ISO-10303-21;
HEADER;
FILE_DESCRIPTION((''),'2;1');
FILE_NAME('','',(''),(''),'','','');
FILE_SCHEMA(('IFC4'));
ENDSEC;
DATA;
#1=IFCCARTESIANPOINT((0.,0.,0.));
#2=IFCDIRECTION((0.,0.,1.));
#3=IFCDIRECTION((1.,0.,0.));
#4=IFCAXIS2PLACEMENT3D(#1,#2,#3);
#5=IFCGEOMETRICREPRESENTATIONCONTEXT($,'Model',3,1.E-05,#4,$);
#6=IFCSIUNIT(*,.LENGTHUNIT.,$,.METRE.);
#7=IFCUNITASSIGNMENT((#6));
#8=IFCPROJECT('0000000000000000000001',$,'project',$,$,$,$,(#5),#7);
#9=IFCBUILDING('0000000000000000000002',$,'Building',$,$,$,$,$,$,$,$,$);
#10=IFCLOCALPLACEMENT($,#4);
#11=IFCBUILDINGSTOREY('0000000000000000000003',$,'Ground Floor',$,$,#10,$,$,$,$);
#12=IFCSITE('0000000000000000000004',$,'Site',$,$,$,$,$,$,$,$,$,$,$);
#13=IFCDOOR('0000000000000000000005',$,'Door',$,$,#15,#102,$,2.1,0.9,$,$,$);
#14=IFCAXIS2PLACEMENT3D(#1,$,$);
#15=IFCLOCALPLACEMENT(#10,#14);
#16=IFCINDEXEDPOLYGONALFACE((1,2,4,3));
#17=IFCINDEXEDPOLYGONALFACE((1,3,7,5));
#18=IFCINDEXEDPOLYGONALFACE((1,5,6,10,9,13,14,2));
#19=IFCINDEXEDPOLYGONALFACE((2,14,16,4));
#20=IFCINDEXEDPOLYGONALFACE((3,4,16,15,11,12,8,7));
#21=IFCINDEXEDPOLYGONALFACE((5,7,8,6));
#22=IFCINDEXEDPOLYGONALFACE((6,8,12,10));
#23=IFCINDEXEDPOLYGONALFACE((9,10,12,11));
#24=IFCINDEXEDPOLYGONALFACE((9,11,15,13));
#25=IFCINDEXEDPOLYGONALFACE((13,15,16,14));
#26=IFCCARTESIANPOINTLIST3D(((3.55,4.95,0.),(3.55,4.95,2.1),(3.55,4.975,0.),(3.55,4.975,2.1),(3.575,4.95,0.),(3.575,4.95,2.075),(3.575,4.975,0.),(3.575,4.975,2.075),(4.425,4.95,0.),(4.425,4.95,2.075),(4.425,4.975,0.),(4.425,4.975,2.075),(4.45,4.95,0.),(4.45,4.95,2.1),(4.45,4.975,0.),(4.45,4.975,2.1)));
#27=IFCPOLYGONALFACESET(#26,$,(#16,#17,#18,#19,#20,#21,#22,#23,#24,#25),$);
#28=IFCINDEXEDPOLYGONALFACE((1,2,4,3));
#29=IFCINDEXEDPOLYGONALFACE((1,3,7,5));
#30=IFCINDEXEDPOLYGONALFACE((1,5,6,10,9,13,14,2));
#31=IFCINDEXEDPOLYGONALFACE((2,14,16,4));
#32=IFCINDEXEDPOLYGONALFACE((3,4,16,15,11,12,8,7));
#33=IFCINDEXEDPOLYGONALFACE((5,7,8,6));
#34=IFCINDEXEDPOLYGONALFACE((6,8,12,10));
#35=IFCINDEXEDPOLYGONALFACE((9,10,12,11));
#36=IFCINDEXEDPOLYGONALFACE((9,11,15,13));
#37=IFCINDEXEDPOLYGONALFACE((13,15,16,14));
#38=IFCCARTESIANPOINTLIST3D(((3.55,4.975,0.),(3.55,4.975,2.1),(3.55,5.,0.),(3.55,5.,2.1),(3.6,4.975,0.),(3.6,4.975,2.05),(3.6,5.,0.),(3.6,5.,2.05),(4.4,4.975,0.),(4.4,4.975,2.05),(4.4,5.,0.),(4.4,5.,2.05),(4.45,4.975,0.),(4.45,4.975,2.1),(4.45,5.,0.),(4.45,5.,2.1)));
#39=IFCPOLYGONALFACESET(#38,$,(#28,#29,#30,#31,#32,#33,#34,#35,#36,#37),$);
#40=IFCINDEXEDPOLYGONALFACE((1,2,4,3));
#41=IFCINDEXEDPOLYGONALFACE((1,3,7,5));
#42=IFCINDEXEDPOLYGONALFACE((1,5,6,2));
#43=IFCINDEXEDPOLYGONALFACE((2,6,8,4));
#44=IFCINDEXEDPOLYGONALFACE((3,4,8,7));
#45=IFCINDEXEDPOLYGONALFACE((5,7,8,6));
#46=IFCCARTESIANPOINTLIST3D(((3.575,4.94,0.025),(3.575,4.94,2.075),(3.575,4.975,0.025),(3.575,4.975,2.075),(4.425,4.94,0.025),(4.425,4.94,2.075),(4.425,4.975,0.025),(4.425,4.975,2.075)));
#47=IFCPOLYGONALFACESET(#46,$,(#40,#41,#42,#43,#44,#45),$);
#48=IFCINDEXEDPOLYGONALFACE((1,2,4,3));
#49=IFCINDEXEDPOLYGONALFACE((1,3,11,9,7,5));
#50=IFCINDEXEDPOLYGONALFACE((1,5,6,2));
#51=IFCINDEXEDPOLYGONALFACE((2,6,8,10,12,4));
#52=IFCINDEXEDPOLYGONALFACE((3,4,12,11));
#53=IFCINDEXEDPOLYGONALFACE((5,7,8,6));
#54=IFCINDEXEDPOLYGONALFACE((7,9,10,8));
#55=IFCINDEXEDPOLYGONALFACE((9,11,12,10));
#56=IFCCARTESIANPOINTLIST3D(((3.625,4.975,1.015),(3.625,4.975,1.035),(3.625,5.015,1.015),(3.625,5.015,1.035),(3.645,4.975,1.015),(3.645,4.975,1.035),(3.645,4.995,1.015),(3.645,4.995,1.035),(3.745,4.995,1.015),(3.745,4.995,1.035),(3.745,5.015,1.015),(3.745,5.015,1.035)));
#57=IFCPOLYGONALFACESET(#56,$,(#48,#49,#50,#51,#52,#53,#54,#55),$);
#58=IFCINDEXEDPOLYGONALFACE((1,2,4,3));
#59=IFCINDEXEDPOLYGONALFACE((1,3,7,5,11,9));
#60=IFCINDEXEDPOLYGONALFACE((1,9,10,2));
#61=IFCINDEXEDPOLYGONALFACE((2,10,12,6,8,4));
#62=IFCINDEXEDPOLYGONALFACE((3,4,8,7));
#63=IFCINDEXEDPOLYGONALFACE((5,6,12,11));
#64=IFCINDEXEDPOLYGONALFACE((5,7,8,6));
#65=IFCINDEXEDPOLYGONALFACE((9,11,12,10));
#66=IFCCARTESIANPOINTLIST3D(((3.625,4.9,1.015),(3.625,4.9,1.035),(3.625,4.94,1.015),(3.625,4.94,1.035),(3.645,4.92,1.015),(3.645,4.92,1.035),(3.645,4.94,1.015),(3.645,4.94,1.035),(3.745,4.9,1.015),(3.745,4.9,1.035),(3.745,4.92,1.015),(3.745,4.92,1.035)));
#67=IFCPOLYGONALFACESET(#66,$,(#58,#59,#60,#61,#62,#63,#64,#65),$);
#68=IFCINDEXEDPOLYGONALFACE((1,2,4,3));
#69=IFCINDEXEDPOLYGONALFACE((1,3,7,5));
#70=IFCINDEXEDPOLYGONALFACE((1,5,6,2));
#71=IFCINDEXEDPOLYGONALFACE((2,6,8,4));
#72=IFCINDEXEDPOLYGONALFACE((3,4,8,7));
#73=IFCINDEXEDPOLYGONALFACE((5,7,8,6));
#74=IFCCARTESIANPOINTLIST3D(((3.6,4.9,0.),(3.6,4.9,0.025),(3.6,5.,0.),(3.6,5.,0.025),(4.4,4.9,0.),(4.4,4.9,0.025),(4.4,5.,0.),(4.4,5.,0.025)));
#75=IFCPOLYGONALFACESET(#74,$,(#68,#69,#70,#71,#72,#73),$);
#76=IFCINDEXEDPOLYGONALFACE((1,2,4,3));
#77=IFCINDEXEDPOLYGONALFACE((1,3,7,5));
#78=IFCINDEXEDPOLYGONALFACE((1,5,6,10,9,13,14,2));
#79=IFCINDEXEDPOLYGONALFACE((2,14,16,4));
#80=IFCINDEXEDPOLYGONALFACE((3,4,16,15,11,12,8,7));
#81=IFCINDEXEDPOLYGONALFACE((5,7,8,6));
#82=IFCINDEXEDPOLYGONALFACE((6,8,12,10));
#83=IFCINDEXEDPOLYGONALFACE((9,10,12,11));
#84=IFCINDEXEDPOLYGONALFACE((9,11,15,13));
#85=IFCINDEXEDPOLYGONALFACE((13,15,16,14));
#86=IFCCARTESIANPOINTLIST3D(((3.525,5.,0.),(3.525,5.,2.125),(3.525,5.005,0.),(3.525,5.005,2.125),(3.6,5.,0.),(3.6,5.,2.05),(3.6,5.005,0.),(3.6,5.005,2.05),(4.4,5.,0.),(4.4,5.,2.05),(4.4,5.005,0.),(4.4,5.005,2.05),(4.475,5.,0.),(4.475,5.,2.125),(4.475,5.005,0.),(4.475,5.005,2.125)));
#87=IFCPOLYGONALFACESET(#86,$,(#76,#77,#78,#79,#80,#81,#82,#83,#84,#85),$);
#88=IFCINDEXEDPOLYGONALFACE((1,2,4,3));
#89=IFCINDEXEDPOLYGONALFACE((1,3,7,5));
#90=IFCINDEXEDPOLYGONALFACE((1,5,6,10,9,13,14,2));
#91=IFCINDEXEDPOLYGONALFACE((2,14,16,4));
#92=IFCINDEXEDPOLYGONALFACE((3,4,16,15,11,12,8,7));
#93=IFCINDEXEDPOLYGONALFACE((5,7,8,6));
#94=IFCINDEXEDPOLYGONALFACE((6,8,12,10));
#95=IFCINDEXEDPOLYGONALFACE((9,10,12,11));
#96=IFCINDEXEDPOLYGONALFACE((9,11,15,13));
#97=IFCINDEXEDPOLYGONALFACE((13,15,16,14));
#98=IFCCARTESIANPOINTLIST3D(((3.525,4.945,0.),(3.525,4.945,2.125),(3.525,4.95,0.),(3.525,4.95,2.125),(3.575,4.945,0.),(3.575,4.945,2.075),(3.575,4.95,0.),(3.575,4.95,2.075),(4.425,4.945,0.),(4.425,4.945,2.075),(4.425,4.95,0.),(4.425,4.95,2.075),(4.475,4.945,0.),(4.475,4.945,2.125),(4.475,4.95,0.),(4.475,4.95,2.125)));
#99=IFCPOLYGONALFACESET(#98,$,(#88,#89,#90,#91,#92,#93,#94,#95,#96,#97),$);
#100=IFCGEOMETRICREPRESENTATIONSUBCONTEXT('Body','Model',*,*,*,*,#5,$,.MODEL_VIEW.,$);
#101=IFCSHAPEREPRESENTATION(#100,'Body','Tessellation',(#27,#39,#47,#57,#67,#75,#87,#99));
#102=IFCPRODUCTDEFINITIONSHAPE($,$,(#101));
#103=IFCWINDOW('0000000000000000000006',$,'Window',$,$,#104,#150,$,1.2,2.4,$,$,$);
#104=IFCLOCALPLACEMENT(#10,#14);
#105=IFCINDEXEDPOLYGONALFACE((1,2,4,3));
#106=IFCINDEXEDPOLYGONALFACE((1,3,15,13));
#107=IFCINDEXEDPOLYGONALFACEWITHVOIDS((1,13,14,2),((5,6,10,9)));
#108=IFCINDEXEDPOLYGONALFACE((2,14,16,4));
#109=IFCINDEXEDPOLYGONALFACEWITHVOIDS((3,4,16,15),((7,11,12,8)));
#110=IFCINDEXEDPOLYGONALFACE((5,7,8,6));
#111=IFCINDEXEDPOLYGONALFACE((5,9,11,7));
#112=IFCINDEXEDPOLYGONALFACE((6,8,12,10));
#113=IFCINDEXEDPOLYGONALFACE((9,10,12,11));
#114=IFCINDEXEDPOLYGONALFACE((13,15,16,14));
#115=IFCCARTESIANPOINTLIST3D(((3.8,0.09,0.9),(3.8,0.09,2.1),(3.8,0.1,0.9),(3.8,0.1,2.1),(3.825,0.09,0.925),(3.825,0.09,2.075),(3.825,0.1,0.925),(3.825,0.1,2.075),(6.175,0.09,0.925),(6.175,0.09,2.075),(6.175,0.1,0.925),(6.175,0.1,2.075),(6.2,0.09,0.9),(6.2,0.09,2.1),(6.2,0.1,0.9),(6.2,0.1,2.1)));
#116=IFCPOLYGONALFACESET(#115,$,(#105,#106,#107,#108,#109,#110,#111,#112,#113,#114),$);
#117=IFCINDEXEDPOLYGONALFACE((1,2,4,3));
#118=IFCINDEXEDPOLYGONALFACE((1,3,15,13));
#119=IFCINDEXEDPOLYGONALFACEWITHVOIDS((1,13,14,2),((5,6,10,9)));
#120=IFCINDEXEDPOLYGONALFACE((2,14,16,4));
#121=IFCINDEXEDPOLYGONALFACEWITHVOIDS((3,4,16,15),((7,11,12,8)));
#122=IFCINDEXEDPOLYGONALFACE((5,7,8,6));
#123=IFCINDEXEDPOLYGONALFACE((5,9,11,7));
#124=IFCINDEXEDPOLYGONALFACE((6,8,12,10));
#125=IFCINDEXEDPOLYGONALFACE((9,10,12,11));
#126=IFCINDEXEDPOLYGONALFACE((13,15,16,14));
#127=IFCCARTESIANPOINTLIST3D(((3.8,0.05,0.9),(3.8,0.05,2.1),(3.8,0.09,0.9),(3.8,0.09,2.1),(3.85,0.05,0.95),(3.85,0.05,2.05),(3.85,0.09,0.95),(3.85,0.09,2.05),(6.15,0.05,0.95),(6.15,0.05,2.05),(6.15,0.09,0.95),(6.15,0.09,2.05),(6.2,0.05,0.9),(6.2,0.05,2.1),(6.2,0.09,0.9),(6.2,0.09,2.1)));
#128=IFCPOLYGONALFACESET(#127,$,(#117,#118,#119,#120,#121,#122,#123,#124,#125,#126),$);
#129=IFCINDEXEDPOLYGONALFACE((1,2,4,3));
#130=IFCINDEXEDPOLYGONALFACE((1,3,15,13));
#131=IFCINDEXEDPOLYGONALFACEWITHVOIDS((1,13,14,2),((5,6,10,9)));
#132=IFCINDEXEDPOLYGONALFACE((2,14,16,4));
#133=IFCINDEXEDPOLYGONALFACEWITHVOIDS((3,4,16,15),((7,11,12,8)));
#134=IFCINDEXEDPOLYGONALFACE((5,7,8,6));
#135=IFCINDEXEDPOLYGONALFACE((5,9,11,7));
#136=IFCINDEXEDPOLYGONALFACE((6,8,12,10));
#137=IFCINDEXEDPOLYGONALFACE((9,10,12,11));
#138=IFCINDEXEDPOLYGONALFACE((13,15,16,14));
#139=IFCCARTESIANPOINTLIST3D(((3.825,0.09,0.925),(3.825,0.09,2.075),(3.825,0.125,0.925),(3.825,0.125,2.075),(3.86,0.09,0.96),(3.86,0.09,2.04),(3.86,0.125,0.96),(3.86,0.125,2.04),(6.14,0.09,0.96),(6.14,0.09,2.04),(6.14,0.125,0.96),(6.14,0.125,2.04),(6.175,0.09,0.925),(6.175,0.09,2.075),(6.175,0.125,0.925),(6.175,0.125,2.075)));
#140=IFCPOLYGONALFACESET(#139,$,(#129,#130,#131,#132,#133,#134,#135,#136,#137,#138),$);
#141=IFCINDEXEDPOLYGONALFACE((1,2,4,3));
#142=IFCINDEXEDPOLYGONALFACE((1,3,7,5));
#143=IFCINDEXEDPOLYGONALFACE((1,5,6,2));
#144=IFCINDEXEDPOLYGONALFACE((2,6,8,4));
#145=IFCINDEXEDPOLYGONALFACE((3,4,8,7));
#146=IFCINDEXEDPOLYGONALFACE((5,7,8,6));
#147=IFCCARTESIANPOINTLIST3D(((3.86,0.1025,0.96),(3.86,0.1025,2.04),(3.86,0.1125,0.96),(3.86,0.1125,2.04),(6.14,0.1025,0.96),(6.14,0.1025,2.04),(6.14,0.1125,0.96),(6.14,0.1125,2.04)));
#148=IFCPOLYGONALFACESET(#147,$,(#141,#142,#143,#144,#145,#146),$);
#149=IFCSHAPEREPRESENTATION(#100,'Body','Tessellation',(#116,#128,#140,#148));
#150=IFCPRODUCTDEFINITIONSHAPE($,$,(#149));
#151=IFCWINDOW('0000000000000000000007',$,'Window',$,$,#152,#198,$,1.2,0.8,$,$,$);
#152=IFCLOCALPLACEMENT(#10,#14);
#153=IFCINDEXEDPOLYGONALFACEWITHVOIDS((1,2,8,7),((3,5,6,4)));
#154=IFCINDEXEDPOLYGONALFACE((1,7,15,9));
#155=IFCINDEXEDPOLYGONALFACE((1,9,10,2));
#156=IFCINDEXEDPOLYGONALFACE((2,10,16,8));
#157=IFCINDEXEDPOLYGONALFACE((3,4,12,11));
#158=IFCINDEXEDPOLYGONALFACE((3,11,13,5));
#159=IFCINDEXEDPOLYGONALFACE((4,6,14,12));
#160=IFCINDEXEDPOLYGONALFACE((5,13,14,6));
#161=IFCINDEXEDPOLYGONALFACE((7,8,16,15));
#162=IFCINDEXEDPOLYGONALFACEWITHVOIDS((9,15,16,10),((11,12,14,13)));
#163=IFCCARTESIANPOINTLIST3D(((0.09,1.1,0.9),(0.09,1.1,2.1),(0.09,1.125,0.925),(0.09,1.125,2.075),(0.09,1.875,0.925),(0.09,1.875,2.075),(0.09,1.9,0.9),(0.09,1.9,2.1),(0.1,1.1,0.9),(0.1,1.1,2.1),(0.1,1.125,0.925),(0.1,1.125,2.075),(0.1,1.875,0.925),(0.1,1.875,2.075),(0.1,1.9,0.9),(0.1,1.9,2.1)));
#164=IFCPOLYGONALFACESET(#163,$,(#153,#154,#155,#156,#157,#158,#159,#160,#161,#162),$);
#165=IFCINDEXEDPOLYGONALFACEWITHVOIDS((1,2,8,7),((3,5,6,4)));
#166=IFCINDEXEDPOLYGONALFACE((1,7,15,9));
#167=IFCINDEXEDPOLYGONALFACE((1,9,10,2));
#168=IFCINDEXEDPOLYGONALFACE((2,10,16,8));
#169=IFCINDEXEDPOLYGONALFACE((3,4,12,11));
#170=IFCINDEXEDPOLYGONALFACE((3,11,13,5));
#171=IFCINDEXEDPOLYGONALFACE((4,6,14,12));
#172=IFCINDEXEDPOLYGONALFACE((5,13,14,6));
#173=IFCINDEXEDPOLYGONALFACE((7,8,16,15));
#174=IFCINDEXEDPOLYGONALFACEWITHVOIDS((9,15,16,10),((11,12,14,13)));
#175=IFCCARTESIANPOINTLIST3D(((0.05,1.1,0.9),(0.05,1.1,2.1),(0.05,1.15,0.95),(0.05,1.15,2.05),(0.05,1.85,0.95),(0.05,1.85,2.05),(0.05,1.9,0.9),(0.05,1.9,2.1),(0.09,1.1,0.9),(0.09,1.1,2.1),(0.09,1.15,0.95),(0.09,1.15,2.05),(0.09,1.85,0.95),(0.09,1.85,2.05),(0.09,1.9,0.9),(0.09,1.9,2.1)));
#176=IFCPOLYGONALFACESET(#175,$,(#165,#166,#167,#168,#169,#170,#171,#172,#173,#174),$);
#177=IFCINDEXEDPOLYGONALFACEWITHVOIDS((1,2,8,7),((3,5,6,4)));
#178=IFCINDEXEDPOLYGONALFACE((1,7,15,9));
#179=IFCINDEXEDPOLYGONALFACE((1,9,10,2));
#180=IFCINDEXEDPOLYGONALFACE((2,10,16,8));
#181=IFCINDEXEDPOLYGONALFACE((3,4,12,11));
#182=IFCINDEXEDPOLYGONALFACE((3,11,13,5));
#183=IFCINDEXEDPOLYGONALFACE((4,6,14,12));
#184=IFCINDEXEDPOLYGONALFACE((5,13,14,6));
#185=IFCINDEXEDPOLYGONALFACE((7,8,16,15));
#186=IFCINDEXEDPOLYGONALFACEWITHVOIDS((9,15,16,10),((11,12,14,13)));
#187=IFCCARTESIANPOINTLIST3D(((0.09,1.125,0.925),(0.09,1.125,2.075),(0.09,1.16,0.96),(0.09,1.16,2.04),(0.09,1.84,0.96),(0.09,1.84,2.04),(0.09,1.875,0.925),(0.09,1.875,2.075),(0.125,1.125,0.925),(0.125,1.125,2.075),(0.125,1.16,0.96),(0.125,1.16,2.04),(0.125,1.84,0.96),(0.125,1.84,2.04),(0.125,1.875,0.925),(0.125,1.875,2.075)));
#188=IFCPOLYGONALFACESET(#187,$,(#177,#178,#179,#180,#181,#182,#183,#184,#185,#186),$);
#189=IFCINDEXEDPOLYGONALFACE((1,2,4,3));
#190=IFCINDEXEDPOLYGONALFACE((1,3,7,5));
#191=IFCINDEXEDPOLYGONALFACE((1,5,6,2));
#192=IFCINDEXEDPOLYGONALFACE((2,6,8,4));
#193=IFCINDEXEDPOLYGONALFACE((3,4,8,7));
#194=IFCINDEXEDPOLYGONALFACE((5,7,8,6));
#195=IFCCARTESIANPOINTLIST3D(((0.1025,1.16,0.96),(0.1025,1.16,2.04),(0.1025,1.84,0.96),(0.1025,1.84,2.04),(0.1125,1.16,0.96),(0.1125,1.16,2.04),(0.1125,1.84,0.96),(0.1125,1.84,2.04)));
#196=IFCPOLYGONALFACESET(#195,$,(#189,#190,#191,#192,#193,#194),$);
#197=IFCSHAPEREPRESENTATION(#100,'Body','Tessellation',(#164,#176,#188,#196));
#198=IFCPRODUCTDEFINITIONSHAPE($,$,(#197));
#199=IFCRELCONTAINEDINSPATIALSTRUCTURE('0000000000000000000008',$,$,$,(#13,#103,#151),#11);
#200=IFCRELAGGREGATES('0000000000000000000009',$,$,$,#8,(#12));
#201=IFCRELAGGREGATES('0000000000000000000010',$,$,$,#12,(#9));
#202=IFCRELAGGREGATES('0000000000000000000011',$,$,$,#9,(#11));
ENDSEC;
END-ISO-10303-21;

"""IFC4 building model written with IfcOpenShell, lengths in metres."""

from ifc_helpers import new_model, si_unit, frame, origin_with_axes, place, context, subcontext, project, spatial, line, indexed_curve, outline, extrude, element, save


model = new_model("IFC4")

# Units and contexts
model_context = context("Model", 3, precision=1e-05, world=origin_with_axes())
body_context = subcontext(model_context, "Body", "Model", "MODEL_VIEW")
ifc_project = project(units=[si_unit("LENGTHUNIT", "METRE")], contexts=[model_context])

# Site, building, storey
site = spatial("IfcSite", under=ifc_project, Name="Site")
building = spatial("IfcBuilding", under=site, Name="Building")
storey_placement = place(None, origin_with_axes())
storey = spatial("IfcBuildingStorey", under=building, at=storey_placement, Name="Ground Floor")

# Door
door_1_placement = place(storey_placement, frame((4.45, 5.0, 0.0), z_axis=(0.0, 0.0, 1.0), x_axis=(-1.0, 0.0, 0.0)))
element("IfcDoor", 1, at=door_1_placement, inside=storey, Name="Door", OverallHeight=2.1, OverallWidth=0.9, context=body_context, shape_type="SweptSolid", body=[
    extrude(outline(indexed_curve([(0.0, 0.0), (0.0, 2.1), (0.9, 2.1), (0.9, 0.0), (0.875, 0.0), (0.875, 2.075), (0.025, 2.075), (0.025, 0.0)], segments=[line(1, 2, 3, 4, 5, 6, 7, 8, 1)])), frame((0.0, 0.025, 0.0), z_axis=(0.0, -1.0, 0.0), x_axis=(1.0, 0.0, 0.0)), (0.0, 0.0, -1.0), 0.025),
    extrude(outline(indexed_curve([(0.0, 0.0), (0.0, 2.1), (0.9, 2.1), (0.9, 0.0), (0.85, 0.0), (0.85, 2.05), (0.05, 2.05), (0.05, 0.0)], segments=[line(1, 2, 3, 4, 5, 6, 7, 8, 1)])), frame((0.0, 0.0, 0.0), z_axis=(0.0, -1.0, 0.0), x_axis=(1.0, 0.0, 0.0)), (0.0, 0.0, -1.0), 0.025),
    extrude(outline(indexed_curve([(0.0, 0.0), (0.85, 0.0), (0.85, 0.035), (0.0, 0.035)], segments=[line(1, 2, 3, 4, 1)])), frame((0.025, 0.025, 0.025), z_axis=(0.0, 0.0, 1.0), x_axis=(1.0, 0.0, 0.0)), (0.0, 0.0, 1.0), 2.05),
    extrude(outline(indexed_curve([(0.0, 0.0), (0.0, -0.04), (-0.12, -0.04), (-0.12, -0.02), (-0.02, -0.02), (-0.02, 0.0)], segments=[line(1, 2, 3, 4, 5, 6, 1)])), frame((0.825, 0.025, 1.015), z_axis=(0.0, 0.0, 1.0), x_axis=(1.0, 0.0, 0.0)), (0.0, 0.0, 1.0), 0.02),
    extrude(outline(indexed_curve([(0.0, 0.0), (0.0, 0.04), (-0.12, 0.04), (-0.12, 0.02), (-0.02, 0.02), (-0.02, 0.0)], segments=[line(1, 2, 3, 4, 5, 6, 1)])), frame((0.825, 0.06, 1.015), z_axis=(0.0, 0.0, 1.0), x_axis=(1.0, 0.0, 0.0)), (0.0, 0.0, 1.0), 0.02),
    extrude(outline(indexed_curve([(0.0, 0.0), (0.8, 0.0), (0.8, 0.1), (0.0, 0.1)], segments=[line(1, 2, 3, 4, 1)])), frame((0.05, 0.0, 0.0), z_axis=(0.0, 0.0, 1.0), x_axis=(1.0, 0.0, 0.0)), (0.0, 0.0, 1.0), 0.025),
    extrude(outline(indexed_curve([(0.0, 0.0), (0.0, 2.125), (0.95, 2.125), (0.95, 0.0), (0.875, 0.0), (0.875, 2.05), (0.075, 2.05), (0.075, 0.0)], segments=[line(1, 2, 3, 4, 5, 6, 7, 8, 1)])), frame((-0.025, -0.005, 0.0), z_axis=(0.0, -1.0, 0.0), x_axis=(1.0, 0.0, 0.0)), (0.0, 0.0, -1.0), 0.005),
    extrude(outline(indexed_curve([(0.0, 0.0), (0.0, 2.125), (0.95, 2.125), (0.95, 0.0), (0.9, 0.0), (0.9, 2.075), (0.05, 2.075), (0.05, 0.0)], segments=[line(1, 2, 3, 4, 5, 6, 7, 8, 1)])), frame((-0.025, 0.05, 0.0), z_axis=(0.0, -1.0, 0.0), x_axis=(1.0, 0.0, 0.0)), (0.0, 0.0, -1.0), 0.005),
])

# Windows
window_1_placement = place(storey_placement, frame((3.8, 0.0, 0.9), z_axis=(0.0, 0.0, 1.0), x_axis=(1.0, 0.0, 0.0)))
element("IfcWindow", 2, at=window_1_placement, inside=storey, Name="Window", OverallHeight=1.2, OverallWidth=2.4, context=body_context, shape_type="SweptSolid", body=[
    extrude(outline(indexed_curve([(0.0, 0.0), (2.4, 0.0), (2.4, 1.2), (0.0, 1.2)], segments=[line(1, 2, 3, 4, 1)]), holes=[indexed_curve([(0.025, 0.025), (2.375, 0.025), (2.375, 1.175), (0.025, 1.175)], segments=[line(1, 2, 3, 4, 1)])]), frame((0.0, 0.09, 0.0), z_axis=(0.0, -1.0, 0.0), x_axis=(1.0, 0.0, 0.0)), (0.0, 0.0, -1.0), 0.01),
    extrude(outline(indexed_curve([(0.0, 0.0), (2.4, 0.0), (2.4, 1.2), (0.0, 1.2)], segments=[line(1, 2, 3, 4, 1)]), holes=[indexed_curve([(0.05, 0.05), (2.35, 0.05), (2.35, 1.15), (0.05, 1.15)], segments=[line(1, 2, 3, 4, 1)])]), frame((0.0, 0.05, 0.0), z_axis=(0.0, -1.0, 0.0), x_axis=(1.0, 0.0, 0.0)), (0.0, 0.0, -1.0), 0.04),
    extrude(outline(indexed_curve([(0.0, 0.0), (2.35, 0.0), (2.35, 1.15), (0.0, 1.15)], segments=[line(1, 2, 3, 4, 1)]), holes=[indexed_curve([(0.035, 0.035), (2.315, 0.035), (2.315, 1.115), (0.035, 1.115)], segments=[line(1, 2, 3, 4, 1)])]), frame((0.025, 0.09, 0.025), z_axis=(0.0, -1.0, 0.0), x_axis=(1.0, 0.0, 0.0)), (0.0, 0.0, -1.0), 0.035),
    extrude(outline(indexed_curve([(0.035, 0.035), (2.315, 0.035), (2.315, 1.115), (0.035, 1.115)], segments=[line(1, 2, 3, 4, 1)])), frame((0.025, 0.1025, 0.025), z_axis=(0.0, -1.0, 0.0), x_axis=(1.0, 0.0, 0.0)), (0.0, 0.0, -1.0), 0.01),
])
window_2_placement = place(storey_placement, frame((0.0, 1.9, 0.9), z_axis=(0.0, 0.0, 1.0), x_axis=(0.0, -1.0, 0.0)))
element("IfcWindow", 3, at=window_2_placement, inside=storey, Name="Window", OverallHeight=1.2, OverallWidth=0.8, context=body_context, shape_type="SweptSolid", body=[
    extrude(outline(indexed_curve([(0.0, 0.0), (0.8, 0.0), (0.8, 1.2), (0.0, 1.2)], segments=[line(1, 2, 3, 4, 1)]), holes=[indexed_curve([(0.025, 0.025), (0.775, 0.025), (0.775, 1.175), (0.025, 1.175)], segments=[line(1, 2, 3, 4, 1)])]), frame((0.0, 0.09, 0.0), z_axis=(0.0, -1.0, 0.0), x_axis=(1.0, 0.0, 0.0)), (0.0, 0.0, -1.0), 0.01),
    extrude(outline(indexed_curve([(0.0, 0.0), (0.8, 0.0), (0.8, 1.2), (0.0, 1.2)], segments=[line(1, 2, 3, 4, 1)]), holes=[indexed_curve([(0.05, 0.05), (0.75, 0.05), (0.75, 1.15), (0.05, 1.15)], segments=[line(1, 2, 3, 4, 1)])]), frame((0.0, 0.05, 0.0), z_axis=(0.0, -1.0, 0.0), x_axis=(1.0, 0.0, 0.0)), (0.0, 0.0, -1.0), 0.04),
    extrude(outline(indexed_curve([(0.0, 0.0), (0.75, 0.0), (0.75, 1.15), (0.0, 1.15)], segments=[line(1, 2, 3, 4, 1)]), holes=[indexed_curve([(0.035, 0.035), (0.715, 0.035), (0.715, 1.115), (0.035, 1.115)], segments=[line(1, 2, 3, 4, 1)])]), frame((0.025, 0.09, 0.025), z_axis=(0.0, -1.0, 0.0), x_axis=(1.0, 0.0, 0.0)), (0.0, 0.0, -1.0), 0.035),
    extrude(outline(indexed_curve([(0.035, 0.035), (0.715, 0.035), (0.715, 1.115), (0.035, 1.115)], segments=[line(1, 2, 3, 4, 1)])), frame((0.025, 0.1025, 0.025), z_axis=(0.0, -1.0, 0.0), x_axis=(1.0, 0.0, 0.0)), (0.0, 0.0, -1.0), 0.01),
])

save(model, "model.ifc")
